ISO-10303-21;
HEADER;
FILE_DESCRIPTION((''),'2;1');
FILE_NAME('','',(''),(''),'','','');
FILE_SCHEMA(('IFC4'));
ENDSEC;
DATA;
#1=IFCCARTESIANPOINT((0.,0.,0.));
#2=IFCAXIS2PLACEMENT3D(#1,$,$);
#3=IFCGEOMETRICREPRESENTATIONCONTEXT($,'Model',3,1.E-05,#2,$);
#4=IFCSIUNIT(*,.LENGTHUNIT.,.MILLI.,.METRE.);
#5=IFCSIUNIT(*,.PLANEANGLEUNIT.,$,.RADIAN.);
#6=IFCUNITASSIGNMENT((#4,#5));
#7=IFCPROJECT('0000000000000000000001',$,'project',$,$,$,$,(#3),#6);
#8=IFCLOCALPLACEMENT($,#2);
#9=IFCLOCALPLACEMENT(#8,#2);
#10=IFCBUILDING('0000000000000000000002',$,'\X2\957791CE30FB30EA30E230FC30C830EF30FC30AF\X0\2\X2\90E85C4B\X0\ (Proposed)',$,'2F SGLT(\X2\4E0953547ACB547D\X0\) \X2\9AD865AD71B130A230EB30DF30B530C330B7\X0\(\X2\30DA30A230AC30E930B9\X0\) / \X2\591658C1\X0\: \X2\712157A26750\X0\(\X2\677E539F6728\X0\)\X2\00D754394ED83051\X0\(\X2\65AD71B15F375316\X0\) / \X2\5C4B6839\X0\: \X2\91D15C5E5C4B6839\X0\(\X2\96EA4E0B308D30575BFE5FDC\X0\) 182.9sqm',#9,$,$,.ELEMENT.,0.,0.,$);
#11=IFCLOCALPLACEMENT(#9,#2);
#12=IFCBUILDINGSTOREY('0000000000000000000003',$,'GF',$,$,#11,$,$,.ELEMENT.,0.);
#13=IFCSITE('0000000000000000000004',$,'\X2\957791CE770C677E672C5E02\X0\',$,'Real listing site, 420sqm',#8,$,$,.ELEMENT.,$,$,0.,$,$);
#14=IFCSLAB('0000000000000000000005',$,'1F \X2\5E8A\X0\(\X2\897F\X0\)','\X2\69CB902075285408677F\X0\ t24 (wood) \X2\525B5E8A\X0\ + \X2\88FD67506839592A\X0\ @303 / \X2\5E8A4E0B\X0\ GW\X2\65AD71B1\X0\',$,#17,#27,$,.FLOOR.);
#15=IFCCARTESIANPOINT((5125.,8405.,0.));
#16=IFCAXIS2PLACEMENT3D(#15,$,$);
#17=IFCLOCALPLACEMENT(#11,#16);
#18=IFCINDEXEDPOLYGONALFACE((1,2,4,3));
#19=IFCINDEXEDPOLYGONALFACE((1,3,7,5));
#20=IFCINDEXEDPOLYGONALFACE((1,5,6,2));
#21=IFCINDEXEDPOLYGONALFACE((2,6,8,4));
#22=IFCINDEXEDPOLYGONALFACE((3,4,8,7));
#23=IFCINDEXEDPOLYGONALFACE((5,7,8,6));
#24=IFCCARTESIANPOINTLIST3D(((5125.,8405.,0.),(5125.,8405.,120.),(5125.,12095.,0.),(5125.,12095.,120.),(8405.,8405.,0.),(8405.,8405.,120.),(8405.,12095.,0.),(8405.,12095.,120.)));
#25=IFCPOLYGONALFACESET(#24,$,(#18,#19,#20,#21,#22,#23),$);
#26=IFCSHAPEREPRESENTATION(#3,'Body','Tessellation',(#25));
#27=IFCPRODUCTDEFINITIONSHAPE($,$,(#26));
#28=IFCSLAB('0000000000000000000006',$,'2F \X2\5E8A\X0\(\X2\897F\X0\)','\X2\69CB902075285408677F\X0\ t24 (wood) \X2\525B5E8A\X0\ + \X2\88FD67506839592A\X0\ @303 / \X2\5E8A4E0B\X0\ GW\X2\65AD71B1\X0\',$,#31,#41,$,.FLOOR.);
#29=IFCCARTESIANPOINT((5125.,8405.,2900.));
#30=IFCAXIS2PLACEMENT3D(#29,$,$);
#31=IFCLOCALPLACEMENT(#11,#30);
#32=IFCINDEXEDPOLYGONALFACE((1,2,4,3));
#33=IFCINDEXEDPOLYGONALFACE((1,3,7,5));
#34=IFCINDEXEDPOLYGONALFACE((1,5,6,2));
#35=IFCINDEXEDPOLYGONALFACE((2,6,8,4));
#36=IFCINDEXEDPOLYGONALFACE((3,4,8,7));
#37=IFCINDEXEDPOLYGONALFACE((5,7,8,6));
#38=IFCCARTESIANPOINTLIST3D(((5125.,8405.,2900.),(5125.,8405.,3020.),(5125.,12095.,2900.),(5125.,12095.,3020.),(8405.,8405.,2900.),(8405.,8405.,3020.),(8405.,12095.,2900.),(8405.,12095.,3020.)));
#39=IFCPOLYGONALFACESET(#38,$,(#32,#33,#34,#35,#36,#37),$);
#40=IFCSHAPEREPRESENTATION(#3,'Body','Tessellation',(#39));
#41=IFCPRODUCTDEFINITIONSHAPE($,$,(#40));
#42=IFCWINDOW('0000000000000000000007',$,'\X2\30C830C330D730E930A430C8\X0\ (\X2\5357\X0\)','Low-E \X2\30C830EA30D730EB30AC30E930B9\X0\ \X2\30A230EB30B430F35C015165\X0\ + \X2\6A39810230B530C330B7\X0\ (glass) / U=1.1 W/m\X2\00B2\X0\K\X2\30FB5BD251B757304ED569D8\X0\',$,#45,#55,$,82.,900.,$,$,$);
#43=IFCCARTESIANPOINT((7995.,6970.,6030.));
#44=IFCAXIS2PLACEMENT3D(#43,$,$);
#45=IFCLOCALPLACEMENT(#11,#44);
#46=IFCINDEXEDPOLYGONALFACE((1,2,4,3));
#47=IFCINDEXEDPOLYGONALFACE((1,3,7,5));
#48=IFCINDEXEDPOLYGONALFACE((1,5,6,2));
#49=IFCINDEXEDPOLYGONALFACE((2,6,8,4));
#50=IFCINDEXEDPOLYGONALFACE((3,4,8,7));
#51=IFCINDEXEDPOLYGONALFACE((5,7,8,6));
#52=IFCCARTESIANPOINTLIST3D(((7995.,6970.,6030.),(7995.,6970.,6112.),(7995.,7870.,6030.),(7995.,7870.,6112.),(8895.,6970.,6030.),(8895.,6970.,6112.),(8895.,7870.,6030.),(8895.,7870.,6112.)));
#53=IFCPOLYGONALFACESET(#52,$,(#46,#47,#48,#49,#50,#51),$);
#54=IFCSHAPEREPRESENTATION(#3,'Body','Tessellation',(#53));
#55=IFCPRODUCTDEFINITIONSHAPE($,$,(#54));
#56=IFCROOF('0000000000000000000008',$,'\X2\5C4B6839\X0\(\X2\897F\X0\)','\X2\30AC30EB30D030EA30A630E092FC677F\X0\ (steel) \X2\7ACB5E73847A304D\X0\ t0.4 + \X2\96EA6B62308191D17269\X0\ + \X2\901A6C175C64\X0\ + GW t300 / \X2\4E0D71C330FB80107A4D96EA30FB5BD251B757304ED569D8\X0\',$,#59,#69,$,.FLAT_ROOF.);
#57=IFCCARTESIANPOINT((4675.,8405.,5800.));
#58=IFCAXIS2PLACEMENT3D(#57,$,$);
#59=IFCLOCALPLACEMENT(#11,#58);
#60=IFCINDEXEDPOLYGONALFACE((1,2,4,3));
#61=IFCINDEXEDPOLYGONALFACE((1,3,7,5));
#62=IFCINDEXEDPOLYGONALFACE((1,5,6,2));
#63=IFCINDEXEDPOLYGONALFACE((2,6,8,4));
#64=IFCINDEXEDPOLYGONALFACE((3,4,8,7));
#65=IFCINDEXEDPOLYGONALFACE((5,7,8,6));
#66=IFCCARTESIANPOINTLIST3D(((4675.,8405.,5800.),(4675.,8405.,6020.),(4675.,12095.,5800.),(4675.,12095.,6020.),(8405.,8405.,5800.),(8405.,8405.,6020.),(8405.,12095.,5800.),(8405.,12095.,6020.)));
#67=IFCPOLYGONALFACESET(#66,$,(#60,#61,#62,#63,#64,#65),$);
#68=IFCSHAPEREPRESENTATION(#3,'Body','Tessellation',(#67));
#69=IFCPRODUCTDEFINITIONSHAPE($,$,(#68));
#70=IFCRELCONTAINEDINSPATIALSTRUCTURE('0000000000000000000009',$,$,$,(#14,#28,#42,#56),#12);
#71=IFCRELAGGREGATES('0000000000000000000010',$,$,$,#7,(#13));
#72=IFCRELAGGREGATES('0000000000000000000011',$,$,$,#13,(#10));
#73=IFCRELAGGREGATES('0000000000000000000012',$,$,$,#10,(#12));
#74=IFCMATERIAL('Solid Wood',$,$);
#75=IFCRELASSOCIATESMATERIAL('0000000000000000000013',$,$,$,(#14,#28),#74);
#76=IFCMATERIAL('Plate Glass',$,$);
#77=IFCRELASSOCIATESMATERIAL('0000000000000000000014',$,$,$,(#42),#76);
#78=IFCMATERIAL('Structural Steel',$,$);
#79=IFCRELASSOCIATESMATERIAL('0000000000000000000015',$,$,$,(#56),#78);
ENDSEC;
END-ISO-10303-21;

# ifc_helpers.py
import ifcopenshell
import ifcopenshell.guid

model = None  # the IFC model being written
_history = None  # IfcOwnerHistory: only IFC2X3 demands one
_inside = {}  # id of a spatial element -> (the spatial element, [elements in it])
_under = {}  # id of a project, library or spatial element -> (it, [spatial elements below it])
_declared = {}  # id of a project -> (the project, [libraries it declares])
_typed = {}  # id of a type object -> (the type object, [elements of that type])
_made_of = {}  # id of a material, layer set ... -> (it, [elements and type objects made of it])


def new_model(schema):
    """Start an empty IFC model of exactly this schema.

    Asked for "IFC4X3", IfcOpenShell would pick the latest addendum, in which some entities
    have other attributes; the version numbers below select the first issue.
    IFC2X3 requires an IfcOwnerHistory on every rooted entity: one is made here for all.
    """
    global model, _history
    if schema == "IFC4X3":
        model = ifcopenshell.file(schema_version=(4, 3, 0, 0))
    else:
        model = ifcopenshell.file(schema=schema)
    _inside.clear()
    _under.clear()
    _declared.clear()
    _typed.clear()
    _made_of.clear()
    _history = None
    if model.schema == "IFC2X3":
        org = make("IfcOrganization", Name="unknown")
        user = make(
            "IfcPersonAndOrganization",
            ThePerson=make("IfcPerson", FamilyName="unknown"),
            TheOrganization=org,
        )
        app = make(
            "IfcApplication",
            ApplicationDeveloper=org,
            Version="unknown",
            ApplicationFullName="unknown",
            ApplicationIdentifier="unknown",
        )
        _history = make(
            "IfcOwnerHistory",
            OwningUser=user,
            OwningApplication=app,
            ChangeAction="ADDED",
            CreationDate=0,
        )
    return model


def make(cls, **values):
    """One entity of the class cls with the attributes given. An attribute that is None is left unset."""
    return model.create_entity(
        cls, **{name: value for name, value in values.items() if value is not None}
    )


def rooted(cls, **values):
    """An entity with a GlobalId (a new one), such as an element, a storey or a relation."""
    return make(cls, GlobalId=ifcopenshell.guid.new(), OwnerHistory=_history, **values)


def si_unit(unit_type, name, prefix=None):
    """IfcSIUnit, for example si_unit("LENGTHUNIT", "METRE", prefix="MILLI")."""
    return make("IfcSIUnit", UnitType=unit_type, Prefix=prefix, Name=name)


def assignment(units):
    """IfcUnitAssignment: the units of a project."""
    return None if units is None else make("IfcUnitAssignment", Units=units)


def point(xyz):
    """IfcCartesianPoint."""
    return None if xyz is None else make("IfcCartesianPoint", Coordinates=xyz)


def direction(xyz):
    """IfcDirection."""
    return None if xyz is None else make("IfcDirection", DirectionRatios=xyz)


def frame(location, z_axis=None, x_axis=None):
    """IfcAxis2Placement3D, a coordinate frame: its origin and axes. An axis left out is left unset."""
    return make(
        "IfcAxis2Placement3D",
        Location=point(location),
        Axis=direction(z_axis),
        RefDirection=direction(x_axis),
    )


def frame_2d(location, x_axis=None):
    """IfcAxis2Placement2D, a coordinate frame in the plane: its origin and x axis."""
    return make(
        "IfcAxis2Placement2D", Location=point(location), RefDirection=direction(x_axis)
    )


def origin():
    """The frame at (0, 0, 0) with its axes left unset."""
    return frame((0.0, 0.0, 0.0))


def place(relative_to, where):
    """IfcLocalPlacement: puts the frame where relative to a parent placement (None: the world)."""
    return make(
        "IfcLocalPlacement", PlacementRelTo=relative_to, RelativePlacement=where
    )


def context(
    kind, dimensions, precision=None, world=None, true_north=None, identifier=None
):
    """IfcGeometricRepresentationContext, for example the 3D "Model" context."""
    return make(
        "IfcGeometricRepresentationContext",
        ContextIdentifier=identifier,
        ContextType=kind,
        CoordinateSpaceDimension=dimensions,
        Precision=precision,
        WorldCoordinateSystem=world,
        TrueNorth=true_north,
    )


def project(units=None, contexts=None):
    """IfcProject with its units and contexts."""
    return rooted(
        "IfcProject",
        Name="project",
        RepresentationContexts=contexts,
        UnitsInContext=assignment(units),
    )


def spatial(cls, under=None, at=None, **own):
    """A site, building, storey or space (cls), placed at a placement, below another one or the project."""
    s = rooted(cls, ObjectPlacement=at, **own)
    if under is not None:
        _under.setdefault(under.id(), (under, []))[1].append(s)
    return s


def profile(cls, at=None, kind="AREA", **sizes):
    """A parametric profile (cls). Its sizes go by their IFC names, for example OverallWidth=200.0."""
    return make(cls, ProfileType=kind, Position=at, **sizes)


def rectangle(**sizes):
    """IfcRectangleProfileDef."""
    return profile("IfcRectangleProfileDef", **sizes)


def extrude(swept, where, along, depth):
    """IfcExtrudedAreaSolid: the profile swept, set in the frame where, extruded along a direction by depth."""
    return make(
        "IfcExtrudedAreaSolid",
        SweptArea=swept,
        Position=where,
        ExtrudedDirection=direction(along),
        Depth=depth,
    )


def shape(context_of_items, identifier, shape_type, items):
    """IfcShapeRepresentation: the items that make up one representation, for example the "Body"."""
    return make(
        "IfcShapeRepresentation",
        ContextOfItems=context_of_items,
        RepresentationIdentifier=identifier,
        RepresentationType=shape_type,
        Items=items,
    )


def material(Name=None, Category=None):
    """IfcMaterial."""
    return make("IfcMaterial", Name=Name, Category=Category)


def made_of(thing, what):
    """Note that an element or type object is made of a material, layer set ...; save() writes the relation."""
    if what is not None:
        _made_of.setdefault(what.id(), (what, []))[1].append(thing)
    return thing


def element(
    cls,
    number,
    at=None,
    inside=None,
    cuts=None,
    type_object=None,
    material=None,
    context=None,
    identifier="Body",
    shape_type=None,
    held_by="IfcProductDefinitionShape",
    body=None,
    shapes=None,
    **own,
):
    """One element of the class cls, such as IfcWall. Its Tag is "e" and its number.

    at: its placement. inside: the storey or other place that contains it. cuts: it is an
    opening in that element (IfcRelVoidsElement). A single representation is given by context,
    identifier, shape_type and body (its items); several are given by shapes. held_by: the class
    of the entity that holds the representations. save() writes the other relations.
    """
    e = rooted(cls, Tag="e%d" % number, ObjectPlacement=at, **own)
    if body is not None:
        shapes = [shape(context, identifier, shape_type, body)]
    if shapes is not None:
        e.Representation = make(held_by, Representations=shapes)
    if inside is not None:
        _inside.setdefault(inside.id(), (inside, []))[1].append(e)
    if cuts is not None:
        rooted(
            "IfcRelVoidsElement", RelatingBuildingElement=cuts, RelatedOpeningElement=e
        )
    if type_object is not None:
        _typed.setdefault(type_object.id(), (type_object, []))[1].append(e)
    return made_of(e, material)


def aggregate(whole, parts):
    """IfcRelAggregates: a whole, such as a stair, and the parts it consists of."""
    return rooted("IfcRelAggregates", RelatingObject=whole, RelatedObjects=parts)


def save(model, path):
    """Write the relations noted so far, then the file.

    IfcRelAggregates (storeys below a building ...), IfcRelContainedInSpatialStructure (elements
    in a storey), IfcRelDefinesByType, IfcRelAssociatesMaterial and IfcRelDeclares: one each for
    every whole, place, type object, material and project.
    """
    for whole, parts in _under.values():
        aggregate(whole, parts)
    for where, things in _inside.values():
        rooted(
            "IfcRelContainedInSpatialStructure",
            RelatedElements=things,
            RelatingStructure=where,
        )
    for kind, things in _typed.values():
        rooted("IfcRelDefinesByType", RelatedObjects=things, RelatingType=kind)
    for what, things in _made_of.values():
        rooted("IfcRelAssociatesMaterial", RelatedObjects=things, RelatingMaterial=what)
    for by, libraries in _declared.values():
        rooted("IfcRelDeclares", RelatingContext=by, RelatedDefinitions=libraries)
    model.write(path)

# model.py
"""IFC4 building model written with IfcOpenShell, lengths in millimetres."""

from ifc_helpers import new_model, si_unit, frame, frame_2d, origin, place, context, project, spatial, rectangle, extrude, material, element, save


model = new_model("IFC4")

# Units and contexts
model_context = context("Model", 3, precision=1e-05, world=origin())
ifc_project = project(units=[si_unit("LENGTHUNIT", "METRE", prefix="MILLI"), si_unit("PLANEANGLEUNIT", "RADIAN")], contexts=[model_context])

# Site, building, storey
site_placement = place(None, origin())
site = spatial("IfcSite", under=ifc_project, at=site_placement, Name="長野県松本市", ObjectType="Real listing site, 420sqm", CompositionType="ELEMENT", RefElevation=0.0)
building_placement = place(site_placement, origin())
building = spatial("IfcBuilding", under=site, at=building_placement, Name="長野・リモートワーク2部屋 (Proposed)", ObjectType="2F SGLT(三協立命) 高断熱アルミサッシ(ペアガラス) / 外壁: 無垢材(松原木)×吹付け(断熱強化) / 屋根: 金属屋根(雪下ろし対応) 182.9sqm", CompositionType="ELEMENT", ElevationOfRefHeight=0.0, ElevationOfTerrain=0.0)
storey_placement = place(building_placement, origin())
storey = spatial("IfcBuildingStorey", under=building, at=storey_placement, Name="GF", CompositionType="ELEMENT", Elevation=0.0)

# Shared definitions
ifc_material_1 = material(Name="Solid Wood")

# Slabs
slab_1_placement = place(storey_placement, frame((5125.0, 8405.0, 0.0)))
element("IfcSlab", 1, at=slab_1_placement, inside=storey, material=ifc_material_1, Name="1F 床(西)", Description="構造用合板 t24 (wood) 剛床 + 製材根太 @303 / 床下 GW断熱", PredefinedType="FLOOR", context=model_context, shape_type="SweptSolid", body=[
    extrude(rectangle(XDim=3280.0, YDim=3690.0, at=frame_2d((1640.0, 1845.0))), frame((5125.0, 8405.0, 0.0)), (0.0, 0.0, 1.0), 120.0),
])
slab_2_placement = place(storey_placement, frame((5125.0, 8405.0, 2900.0)))
element("IfcSlab", 2, at=slab_2_placement, inside=storey, material=ifc_material_1, Name="2F 床(西)", Description="構造用合板 t24 (wood) 剛床 + 製材根太 @303 / 床下 GW断熱", PredefinedType="FLOOR", context=model_context, shape_type="SweptSolid", body=[
    extrude(rectangle(XDim=3280.0, YDim=3690.0, at=frame_2d((1640.0, 1845.0))), frame((5125.0, 8405.0, 2900.0)), (0.0, 0.0, 1.0), 120.0),
])

# Window
ifc_material_2 = material(Name="Plate Glass")
window_placement = place(storey_placement, frame((7995.0, 6970.0, 6030.0)))
element("IfcWindow", 3, at=window_placement, inside=storey, material=ifc_material_2, Name="トップライト (南)", Description="Low-E トリプルガラス アルゴン封入 + 樹脂サッシ (glass) / U=1.1 W/m²K・寒冷地仕様", OverallHeight=82.0, OverallWidth=900.0, context=model_context, shape_type="SweptSolid", body=[
    extrude(rectangle(XDim=900.0, YDim=900.0, at=frame_2d((450.0, 450.0))), frame((7995.0, 6970.0, 6030.0)), (0.0, 0.0, 1.0), 82.0),
])

# Roof
ifc_material_3 = material(Name="Structural Steel")
for number, where, name in (
    (4, (4675.0, 8405.0, 5800.0), "屋根(西)"),
):
    element("IfcRoof", number, at=place(storey_placement, frame(where)), inside=storey, material=ifc_material_3, Name=name, Description="ガルバリウム鋼板 (steel) 立平葺き t0.4 + 雪止め金物 + 通気層 + GW t300 / 不燃・耐積雪・寒冷地仕様", PredefinedType="FLAT_ROOF", context=model_context, shape_type="SweptSolid", body=[
        extrude(rectangle(XDim=3730.0, YDim=3690.0, at=frame_2d((1865.0, 1845.0))), frame((4675.0, 8405.0, 5800.0)), (0.0, 0.0, 1.0), 220.0),
    ])

save(model, "model.ifc")
